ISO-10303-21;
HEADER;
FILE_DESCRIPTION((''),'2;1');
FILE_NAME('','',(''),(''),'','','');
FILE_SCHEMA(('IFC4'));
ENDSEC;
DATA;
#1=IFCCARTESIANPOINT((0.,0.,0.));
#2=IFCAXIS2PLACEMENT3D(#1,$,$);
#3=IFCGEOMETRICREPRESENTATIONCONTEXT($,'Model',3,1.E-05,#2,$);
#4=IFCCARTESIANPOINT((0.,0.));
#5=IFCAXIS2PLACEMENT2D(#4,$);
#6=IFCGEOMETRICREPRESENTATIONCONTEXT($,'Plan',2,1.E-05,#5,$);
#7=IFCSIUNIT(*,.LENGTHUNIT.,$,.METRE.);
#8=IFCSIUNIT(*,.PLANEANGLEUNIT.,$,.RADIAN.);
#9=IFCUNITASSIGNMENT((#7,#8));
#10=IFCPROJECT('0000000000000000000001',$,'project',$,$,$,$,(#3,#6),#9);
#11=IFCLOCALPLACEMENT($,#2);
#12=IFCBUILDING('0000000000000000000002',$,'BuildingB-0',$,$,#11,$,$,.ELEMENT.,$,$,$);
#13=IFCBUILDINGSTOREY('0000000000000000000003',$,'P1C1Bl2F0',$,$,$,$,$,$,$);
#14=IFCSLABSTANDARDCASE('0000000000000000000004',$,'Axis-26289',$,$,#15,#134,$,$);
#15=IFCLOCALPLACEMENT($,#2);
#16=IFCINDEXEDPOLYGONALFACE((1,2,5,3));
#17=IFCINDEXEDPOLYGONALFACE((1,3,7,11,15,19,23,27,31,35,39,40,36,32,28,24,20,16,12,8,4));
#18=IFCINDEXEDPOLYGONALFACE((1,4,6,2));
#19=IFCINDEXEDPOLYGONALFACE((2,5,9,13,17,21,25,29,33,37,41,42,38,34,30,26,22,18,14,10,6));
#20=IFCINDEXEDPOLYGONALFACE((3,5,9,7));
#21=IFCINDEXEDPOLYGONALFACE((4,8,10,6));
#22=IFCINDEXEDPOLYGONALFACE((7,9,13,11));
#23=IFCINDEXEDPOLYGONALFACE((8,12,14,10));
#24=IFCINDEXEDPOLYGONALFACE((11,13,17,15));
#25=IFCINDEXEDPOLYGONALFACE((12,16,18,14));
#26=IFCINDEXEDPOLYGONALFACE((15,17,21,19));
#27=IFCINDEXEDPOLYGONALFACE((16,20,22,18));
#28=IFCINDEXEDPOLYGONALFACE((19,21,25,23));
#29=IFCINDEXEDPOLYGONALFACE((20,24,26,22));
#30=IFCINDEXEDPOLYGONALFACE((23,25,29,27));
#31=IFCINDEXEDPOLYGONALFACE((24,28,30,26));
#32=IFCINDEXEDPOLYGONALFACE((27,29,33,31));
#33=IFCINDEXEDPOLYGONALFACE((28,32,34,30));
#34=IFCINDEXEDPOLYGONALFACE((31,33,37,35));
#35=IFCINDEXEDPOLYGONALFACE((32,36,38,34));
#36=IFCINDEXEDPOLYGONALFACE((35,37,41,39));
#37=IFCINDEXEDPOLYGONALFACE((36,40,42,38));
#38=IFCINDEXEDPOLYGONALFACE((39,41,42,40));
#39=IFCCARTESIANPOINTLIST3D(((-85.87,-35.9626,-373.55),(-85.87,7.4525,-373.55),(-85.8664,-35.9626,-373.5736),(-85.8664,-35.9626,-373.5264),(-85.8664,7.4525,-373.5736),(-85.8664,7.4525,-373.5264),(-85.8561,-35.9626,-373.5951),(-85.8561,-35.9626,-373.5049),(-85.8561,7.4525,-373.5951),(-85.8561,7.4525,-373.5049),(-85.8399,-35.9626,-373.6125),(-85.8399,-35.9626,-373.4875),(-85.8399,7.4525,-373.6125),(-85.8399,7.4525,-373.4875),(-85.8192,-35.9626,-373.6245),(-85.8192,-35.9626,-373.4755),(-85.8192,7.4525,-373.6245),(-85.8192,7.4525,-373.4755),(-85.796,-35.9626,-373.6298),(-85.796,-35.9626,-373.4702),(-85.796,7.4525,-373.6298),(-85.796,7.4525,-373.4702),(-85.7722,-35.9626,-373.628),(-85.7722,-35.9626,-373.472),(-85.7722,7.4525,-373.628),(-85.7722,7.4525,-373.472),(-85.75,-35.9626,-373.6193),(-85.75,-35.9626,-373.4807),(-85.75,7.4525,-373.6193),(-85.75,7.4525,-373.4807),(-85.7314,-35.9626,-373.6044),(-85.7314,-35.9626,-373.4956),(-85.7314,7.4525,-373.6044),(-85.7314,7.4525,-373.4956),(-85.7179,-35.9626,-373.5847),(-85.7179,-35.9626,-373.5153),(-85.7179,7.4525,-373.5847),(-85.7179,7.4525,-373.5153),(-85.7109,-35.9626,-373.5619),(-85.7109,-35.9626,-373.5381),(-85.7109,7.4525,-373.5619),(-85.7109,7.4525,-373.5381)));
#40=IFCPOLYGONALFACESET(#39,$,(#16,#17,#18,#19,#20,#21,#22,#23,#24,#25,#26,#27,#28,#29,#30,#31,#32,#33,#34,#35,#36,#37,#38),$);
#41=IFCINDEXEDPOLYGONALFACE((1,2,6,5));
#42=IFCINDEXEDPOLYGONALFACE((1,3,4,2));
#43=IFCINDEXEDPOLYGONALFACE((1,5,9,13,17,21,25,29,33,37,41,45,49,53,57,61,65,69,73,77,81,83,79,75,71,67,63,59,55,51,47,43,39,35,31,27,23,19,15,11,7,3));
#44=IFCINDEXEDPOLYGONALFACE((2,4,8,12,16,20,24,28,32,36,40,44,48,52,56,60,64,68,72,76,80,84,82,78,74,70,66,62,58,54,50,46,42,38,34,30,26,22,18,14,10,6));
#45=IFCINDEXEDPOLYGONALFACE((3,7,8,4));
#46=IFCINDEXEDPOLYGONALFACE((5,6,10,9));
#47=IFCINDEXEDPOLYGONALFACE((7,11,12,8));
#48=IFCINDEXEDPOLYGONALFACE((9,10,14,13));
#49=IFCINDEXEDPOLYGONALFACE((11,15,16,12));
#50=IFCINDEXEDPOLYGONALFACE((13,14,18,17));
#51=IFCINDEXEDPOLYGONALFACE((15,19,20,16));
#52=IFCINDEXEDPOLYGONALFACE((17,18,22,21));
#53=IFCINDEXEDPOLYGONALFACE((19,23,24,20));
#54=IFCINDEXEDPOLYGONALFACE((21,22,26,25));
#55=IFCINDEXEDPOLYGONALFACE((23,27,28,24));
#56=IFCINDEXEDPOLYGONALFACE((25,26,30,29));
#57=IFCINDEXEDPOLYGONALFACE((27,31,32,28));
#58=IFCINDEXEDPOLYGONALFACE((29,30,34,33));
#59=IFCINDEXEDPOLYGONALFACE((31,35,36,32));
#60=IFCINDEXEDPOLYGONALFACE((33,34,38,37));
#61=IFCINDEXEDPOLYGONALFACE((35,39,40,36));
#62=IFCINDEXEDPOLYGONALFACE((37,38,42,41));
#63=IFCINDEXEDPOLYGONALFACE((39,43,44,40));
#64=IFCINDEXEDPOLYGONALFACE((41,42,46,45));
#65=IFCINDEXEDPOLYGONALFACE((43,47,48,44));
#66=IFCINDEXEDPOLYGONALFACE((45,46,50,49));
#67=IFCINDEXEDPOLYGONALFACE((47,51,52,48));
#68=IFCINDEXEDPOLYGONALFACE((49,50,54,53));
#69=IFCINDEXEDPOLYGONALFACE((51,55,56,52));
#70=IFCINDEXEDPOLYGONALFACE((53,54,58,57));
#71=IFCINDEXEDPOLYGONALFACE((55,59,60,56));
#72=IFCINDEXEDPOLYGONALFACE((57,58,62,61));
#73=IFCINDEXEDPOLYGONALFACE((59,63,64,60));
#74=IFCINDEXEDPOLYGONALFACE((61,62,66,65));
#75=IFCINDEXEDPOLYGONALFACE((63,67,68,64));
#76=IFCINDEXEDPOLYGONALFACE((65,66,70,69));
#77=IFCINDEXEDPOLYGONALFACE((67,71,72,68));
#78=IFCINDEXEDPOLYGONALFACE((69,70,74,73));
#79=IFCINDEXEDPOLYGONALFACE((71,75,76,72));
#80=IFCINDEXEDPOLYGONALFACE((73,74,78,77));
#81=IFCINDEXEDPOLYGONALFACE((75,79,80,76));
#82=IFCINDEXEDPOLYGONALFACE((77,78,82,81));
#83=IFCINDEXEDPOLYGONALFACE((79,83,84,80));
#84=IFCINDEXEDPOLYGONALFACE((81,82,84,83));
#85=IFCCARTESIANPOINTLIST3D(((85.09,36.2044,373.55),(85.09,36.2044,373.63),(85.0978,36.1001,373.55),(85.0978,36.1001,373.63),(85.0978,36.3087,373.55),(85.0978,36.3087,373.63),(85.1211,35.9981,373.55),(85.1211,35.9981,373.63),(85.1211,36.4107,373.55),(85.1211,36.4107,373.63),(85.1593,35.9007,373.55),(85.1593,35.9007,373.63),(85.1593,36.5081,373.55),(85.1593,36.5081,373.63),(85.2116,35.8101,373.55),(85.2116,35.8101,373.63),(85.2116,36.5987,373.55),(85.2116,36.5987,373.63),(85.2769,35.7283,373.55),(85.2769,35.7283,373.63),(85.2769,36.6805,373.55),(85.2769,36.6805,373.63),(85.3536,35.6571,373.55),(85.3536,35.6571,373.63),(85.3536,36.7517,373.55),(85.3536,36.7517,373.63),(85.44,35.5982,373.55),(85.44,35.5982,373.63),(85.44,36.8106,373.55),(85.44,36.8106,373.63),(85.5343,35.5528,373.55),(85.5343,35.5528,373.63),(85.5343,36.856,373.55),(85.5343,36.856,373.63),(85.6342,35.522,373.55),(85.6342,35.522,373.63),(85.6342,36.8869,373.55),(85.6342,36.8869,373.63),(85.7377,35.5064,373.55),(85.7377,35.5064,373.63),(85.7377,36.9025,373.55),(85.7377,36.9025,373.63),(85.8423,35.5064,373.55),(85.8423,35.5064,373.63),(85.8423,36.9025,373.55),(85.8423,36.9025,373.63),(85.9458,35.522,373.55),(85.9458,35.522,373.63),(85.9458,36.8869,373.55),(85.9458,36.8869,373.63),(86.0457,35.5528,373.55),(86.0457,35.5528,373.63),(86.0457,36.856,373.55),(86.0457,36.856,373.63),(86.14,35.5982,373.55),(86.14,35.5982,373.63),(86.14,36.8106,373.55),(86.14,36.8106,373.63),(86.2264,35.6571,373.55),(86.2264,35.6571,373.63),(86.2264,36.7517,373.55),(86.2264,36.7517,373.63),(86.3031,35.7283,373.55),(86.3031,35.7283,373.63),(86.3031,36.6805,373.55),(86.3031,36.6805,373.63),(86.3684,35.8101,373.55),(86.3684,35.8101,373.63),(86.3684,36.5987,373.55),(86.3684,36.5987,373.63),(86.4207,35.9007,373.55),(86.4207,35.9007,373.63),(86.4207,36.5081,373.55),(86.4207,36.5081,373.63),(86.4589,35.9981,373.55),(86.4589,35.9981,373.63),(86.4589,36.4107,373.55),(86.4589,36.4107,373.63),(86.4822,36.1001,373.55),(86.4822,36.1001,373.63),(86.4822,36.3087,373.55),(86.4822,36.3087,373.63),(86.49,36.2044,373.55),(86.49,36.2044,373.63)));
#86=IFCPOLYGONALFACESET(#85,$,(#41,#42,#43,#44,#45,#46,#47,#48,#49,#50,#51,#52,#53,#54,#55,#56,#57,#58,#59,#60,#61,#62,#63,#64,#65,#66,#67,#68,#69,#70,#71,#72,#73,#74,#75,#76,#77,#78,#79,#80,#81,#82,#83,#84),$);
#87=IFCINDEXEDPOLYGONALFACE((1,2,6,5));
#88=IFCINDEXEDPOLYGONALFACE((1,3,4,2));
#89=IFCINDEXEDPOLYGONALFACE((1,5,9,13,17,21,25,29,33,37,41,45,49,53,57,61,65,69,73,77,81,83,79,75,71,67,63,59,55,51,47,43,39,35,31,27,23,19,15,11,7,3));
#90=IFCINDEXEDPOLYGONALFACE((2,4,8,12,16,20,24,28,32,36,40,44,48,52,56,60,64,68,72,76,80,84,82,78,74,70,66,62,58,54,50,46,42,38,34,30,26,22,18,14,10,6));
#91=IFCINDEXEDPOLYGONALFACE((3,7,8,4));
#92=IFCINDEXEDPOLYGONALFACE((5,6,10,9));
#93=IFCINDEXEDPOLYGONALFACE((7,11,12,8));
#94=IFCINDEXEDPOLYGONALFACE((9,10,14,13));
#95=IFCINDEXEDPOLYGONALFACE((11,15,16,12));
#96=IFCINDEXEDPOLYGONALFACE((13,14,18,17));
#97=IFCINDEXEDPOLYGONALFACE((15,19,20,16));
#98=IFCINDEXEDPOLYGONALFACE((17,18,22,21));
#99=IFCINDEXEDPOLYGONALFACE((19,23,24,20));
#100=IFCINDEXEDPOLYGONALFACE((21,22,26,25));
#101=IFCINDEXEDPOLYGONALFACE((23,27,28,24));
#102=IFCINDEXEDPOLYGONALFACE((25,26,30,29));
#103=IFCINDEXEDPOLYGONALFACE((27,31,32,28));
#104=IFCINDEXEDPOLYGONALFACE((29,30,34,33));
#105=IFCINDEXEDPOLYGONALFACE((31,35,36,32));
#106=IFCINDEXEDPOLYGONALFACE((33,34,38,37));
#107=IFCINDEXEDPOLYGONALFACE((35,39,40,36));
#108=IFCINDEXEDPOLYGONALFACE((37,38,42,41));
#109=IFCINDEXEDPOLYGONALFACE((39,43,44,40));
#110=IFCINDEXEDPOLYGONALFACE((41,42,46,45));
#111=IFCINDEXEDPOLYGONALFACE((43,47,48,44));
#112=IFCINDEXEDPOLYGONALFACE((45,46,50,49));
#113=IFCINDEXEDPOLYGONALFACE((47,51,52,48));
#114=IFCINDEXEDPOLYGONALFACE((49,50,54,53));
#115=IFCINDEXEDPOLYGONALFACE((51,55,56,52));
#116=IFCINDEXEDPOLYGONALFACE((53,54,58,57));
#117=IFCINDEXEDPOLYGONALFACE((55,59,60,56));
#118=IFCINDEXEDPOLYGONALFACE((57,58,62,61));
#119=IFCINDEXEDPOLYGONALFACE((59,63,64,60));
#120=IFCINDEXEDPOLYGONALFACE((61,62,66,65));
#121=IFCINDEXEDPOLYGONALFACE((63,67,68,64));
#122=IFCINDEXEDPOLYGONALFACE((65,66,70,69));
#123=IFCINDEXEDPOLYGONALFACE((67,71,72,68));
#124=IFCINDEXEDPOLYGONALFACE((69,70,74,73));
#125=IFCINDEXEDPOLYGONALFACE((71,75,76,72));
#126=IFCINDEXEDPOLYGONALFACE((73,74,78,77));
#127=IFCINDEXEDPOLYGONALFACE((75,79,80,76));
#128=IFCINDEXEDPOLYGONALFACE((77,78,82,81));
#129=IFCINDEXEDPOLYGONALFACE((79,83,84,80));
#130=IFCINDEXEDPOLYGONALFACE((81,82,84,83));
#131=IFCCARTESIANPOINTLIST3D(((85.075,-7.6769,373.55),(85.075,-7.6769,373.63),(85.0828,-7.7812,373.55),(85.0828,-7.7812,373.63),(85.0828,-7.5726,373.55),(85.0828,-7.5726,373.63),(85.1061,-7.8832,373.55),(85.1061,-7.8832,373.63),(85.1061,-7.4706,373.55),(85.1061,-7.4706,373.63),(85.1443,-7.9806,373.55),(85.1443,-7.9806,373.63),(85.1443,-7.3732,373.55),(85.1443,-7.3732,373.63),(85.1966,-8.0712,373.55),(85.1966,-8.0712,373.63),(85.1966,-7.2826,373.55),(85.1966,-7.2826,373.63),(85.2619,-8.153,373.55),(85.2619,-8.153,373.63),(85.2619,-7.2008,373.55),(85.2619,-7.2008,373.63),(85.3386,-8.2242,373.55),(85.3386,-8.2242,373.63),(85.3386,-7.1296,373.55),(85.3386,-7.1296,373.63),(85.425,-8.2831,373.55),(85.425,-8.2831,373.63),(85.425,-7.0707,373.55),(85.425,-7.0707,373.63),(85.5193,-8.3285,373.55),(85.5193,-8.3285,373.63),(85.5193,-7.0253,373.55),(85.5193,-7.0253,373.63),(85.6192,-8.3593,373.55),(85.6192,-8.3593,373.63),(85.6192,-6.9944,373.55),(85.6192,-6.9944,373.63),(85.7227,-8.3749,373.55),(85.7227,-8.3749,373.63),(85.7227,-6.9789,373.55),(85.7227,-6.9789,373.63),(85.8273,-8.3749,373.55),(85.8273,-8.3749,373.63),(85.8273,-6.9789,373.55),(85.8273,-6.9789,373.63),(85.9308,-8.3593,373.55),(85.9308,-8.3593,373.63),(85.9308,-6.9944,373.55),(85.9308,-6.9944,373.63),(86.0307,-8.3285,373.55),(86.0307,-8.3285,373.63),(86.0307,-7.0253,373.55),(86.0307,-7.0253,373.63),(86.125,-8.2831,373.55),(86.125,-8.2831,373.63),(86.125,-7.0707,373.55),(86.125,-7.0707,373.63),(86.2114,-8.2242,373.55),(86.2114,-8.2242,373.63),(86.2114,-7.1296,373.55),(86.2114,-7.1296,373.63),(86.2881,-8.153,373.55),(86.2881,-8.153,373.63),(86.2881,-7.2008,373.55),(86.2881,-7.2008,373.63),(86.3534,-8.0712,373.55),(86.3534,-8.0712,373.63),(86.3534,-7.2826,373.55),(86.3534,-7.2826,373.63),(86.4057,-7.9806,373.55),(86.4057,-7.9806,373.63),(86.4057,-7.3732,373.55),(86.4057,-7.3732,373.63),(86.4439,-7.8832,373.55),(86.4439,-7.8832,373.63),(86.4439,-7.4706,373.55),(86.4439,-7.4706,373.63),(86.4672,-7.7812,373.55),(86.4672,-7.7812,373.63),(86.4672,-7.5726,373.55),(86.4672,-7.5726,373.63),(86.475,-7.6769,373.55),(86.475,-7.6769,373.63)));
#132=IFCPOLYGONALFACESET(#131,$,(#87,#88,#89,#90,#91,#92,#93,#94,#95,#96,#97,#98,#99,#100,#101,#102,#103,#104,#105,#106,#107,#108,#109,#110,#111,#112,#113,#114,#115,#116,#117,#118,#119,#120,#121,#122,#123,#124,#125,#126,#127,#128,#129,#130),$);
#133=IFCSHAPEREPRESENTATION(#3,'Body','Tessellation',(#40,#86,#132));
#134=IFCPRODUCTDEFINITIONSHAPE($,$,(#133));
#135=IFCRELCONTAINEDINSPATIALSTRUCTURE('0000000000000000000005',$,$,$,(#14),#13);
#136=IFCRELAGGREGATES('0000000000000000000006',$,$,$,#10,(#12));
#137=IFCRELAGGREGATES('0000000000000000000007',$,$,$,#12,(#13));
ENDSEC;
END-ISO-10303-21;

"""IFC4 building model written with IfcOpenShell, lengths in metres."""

from ifc_helpers import new_model, entity, si_unit, frame, origin, origin_2d, place, context, project, spatial, circle, extrude, element, save


model = new_model("IFC4")

# Units and contexts
model_context = context("Model", 3, precision=1e-05, world=origin())
plan_context = context("Plan", 2, precision=1e-05, world=origin_2d())
ifc_project = project(units=[si_unit("LENGTHUNIT", "METRE"), si_unit("PLANEANGLEUNIT", "RADIAN")], contexts=[model_context, plan_context])

# Building, storey
building_placement = place(None, origin())
building = spatial("IfcBuilding", under=ifc_project, at=building_placement, Name="BuildingB-0", CompositionType="ELEMENT")
storey = spatial("IfcBuildingStorey", under=building, Name="P1C1Bl2F0")

# Slab
element("IfcSlabStandardCase", 1, inside=storey, Name="Axis-26289", context=model_context, shape_type="AdvancedSweptSolid", body=[
    entity("IfcSurfaceCurveSweptAreaSolid", entity("IfcCircleProfileDef", "AREA", None, None, 0.08), None, entity("IfcPolyline", [entity("IfcCartesianPoint", [85.79, 35.9626, 373.55]), entity("IfcCartesianPoint", [85.79, -7.4525, 373.55])]), None, None, entity("IfcPlane", entity("IfcAxis2Placement3D", entity("IfcCartesianPoint", [85.79, 35.9626, 373.55]), entity("IfcDirection", [0.0, 0.0, 1.0]), entity("IfcDirection", [1.0, 0.0, 0.0])))),
    extrude(circle(Radius=0.7), frame((85.79, 36.2044, 373.55)), (0.0, 0.0, 1.0), 0.08),
    extrude(circle(Radius=0.7), frame((85.775, -7.6769, 373.55)), (0.0, 0.0, 1.0), 0.08),
])

save(model, "model.ifc")
